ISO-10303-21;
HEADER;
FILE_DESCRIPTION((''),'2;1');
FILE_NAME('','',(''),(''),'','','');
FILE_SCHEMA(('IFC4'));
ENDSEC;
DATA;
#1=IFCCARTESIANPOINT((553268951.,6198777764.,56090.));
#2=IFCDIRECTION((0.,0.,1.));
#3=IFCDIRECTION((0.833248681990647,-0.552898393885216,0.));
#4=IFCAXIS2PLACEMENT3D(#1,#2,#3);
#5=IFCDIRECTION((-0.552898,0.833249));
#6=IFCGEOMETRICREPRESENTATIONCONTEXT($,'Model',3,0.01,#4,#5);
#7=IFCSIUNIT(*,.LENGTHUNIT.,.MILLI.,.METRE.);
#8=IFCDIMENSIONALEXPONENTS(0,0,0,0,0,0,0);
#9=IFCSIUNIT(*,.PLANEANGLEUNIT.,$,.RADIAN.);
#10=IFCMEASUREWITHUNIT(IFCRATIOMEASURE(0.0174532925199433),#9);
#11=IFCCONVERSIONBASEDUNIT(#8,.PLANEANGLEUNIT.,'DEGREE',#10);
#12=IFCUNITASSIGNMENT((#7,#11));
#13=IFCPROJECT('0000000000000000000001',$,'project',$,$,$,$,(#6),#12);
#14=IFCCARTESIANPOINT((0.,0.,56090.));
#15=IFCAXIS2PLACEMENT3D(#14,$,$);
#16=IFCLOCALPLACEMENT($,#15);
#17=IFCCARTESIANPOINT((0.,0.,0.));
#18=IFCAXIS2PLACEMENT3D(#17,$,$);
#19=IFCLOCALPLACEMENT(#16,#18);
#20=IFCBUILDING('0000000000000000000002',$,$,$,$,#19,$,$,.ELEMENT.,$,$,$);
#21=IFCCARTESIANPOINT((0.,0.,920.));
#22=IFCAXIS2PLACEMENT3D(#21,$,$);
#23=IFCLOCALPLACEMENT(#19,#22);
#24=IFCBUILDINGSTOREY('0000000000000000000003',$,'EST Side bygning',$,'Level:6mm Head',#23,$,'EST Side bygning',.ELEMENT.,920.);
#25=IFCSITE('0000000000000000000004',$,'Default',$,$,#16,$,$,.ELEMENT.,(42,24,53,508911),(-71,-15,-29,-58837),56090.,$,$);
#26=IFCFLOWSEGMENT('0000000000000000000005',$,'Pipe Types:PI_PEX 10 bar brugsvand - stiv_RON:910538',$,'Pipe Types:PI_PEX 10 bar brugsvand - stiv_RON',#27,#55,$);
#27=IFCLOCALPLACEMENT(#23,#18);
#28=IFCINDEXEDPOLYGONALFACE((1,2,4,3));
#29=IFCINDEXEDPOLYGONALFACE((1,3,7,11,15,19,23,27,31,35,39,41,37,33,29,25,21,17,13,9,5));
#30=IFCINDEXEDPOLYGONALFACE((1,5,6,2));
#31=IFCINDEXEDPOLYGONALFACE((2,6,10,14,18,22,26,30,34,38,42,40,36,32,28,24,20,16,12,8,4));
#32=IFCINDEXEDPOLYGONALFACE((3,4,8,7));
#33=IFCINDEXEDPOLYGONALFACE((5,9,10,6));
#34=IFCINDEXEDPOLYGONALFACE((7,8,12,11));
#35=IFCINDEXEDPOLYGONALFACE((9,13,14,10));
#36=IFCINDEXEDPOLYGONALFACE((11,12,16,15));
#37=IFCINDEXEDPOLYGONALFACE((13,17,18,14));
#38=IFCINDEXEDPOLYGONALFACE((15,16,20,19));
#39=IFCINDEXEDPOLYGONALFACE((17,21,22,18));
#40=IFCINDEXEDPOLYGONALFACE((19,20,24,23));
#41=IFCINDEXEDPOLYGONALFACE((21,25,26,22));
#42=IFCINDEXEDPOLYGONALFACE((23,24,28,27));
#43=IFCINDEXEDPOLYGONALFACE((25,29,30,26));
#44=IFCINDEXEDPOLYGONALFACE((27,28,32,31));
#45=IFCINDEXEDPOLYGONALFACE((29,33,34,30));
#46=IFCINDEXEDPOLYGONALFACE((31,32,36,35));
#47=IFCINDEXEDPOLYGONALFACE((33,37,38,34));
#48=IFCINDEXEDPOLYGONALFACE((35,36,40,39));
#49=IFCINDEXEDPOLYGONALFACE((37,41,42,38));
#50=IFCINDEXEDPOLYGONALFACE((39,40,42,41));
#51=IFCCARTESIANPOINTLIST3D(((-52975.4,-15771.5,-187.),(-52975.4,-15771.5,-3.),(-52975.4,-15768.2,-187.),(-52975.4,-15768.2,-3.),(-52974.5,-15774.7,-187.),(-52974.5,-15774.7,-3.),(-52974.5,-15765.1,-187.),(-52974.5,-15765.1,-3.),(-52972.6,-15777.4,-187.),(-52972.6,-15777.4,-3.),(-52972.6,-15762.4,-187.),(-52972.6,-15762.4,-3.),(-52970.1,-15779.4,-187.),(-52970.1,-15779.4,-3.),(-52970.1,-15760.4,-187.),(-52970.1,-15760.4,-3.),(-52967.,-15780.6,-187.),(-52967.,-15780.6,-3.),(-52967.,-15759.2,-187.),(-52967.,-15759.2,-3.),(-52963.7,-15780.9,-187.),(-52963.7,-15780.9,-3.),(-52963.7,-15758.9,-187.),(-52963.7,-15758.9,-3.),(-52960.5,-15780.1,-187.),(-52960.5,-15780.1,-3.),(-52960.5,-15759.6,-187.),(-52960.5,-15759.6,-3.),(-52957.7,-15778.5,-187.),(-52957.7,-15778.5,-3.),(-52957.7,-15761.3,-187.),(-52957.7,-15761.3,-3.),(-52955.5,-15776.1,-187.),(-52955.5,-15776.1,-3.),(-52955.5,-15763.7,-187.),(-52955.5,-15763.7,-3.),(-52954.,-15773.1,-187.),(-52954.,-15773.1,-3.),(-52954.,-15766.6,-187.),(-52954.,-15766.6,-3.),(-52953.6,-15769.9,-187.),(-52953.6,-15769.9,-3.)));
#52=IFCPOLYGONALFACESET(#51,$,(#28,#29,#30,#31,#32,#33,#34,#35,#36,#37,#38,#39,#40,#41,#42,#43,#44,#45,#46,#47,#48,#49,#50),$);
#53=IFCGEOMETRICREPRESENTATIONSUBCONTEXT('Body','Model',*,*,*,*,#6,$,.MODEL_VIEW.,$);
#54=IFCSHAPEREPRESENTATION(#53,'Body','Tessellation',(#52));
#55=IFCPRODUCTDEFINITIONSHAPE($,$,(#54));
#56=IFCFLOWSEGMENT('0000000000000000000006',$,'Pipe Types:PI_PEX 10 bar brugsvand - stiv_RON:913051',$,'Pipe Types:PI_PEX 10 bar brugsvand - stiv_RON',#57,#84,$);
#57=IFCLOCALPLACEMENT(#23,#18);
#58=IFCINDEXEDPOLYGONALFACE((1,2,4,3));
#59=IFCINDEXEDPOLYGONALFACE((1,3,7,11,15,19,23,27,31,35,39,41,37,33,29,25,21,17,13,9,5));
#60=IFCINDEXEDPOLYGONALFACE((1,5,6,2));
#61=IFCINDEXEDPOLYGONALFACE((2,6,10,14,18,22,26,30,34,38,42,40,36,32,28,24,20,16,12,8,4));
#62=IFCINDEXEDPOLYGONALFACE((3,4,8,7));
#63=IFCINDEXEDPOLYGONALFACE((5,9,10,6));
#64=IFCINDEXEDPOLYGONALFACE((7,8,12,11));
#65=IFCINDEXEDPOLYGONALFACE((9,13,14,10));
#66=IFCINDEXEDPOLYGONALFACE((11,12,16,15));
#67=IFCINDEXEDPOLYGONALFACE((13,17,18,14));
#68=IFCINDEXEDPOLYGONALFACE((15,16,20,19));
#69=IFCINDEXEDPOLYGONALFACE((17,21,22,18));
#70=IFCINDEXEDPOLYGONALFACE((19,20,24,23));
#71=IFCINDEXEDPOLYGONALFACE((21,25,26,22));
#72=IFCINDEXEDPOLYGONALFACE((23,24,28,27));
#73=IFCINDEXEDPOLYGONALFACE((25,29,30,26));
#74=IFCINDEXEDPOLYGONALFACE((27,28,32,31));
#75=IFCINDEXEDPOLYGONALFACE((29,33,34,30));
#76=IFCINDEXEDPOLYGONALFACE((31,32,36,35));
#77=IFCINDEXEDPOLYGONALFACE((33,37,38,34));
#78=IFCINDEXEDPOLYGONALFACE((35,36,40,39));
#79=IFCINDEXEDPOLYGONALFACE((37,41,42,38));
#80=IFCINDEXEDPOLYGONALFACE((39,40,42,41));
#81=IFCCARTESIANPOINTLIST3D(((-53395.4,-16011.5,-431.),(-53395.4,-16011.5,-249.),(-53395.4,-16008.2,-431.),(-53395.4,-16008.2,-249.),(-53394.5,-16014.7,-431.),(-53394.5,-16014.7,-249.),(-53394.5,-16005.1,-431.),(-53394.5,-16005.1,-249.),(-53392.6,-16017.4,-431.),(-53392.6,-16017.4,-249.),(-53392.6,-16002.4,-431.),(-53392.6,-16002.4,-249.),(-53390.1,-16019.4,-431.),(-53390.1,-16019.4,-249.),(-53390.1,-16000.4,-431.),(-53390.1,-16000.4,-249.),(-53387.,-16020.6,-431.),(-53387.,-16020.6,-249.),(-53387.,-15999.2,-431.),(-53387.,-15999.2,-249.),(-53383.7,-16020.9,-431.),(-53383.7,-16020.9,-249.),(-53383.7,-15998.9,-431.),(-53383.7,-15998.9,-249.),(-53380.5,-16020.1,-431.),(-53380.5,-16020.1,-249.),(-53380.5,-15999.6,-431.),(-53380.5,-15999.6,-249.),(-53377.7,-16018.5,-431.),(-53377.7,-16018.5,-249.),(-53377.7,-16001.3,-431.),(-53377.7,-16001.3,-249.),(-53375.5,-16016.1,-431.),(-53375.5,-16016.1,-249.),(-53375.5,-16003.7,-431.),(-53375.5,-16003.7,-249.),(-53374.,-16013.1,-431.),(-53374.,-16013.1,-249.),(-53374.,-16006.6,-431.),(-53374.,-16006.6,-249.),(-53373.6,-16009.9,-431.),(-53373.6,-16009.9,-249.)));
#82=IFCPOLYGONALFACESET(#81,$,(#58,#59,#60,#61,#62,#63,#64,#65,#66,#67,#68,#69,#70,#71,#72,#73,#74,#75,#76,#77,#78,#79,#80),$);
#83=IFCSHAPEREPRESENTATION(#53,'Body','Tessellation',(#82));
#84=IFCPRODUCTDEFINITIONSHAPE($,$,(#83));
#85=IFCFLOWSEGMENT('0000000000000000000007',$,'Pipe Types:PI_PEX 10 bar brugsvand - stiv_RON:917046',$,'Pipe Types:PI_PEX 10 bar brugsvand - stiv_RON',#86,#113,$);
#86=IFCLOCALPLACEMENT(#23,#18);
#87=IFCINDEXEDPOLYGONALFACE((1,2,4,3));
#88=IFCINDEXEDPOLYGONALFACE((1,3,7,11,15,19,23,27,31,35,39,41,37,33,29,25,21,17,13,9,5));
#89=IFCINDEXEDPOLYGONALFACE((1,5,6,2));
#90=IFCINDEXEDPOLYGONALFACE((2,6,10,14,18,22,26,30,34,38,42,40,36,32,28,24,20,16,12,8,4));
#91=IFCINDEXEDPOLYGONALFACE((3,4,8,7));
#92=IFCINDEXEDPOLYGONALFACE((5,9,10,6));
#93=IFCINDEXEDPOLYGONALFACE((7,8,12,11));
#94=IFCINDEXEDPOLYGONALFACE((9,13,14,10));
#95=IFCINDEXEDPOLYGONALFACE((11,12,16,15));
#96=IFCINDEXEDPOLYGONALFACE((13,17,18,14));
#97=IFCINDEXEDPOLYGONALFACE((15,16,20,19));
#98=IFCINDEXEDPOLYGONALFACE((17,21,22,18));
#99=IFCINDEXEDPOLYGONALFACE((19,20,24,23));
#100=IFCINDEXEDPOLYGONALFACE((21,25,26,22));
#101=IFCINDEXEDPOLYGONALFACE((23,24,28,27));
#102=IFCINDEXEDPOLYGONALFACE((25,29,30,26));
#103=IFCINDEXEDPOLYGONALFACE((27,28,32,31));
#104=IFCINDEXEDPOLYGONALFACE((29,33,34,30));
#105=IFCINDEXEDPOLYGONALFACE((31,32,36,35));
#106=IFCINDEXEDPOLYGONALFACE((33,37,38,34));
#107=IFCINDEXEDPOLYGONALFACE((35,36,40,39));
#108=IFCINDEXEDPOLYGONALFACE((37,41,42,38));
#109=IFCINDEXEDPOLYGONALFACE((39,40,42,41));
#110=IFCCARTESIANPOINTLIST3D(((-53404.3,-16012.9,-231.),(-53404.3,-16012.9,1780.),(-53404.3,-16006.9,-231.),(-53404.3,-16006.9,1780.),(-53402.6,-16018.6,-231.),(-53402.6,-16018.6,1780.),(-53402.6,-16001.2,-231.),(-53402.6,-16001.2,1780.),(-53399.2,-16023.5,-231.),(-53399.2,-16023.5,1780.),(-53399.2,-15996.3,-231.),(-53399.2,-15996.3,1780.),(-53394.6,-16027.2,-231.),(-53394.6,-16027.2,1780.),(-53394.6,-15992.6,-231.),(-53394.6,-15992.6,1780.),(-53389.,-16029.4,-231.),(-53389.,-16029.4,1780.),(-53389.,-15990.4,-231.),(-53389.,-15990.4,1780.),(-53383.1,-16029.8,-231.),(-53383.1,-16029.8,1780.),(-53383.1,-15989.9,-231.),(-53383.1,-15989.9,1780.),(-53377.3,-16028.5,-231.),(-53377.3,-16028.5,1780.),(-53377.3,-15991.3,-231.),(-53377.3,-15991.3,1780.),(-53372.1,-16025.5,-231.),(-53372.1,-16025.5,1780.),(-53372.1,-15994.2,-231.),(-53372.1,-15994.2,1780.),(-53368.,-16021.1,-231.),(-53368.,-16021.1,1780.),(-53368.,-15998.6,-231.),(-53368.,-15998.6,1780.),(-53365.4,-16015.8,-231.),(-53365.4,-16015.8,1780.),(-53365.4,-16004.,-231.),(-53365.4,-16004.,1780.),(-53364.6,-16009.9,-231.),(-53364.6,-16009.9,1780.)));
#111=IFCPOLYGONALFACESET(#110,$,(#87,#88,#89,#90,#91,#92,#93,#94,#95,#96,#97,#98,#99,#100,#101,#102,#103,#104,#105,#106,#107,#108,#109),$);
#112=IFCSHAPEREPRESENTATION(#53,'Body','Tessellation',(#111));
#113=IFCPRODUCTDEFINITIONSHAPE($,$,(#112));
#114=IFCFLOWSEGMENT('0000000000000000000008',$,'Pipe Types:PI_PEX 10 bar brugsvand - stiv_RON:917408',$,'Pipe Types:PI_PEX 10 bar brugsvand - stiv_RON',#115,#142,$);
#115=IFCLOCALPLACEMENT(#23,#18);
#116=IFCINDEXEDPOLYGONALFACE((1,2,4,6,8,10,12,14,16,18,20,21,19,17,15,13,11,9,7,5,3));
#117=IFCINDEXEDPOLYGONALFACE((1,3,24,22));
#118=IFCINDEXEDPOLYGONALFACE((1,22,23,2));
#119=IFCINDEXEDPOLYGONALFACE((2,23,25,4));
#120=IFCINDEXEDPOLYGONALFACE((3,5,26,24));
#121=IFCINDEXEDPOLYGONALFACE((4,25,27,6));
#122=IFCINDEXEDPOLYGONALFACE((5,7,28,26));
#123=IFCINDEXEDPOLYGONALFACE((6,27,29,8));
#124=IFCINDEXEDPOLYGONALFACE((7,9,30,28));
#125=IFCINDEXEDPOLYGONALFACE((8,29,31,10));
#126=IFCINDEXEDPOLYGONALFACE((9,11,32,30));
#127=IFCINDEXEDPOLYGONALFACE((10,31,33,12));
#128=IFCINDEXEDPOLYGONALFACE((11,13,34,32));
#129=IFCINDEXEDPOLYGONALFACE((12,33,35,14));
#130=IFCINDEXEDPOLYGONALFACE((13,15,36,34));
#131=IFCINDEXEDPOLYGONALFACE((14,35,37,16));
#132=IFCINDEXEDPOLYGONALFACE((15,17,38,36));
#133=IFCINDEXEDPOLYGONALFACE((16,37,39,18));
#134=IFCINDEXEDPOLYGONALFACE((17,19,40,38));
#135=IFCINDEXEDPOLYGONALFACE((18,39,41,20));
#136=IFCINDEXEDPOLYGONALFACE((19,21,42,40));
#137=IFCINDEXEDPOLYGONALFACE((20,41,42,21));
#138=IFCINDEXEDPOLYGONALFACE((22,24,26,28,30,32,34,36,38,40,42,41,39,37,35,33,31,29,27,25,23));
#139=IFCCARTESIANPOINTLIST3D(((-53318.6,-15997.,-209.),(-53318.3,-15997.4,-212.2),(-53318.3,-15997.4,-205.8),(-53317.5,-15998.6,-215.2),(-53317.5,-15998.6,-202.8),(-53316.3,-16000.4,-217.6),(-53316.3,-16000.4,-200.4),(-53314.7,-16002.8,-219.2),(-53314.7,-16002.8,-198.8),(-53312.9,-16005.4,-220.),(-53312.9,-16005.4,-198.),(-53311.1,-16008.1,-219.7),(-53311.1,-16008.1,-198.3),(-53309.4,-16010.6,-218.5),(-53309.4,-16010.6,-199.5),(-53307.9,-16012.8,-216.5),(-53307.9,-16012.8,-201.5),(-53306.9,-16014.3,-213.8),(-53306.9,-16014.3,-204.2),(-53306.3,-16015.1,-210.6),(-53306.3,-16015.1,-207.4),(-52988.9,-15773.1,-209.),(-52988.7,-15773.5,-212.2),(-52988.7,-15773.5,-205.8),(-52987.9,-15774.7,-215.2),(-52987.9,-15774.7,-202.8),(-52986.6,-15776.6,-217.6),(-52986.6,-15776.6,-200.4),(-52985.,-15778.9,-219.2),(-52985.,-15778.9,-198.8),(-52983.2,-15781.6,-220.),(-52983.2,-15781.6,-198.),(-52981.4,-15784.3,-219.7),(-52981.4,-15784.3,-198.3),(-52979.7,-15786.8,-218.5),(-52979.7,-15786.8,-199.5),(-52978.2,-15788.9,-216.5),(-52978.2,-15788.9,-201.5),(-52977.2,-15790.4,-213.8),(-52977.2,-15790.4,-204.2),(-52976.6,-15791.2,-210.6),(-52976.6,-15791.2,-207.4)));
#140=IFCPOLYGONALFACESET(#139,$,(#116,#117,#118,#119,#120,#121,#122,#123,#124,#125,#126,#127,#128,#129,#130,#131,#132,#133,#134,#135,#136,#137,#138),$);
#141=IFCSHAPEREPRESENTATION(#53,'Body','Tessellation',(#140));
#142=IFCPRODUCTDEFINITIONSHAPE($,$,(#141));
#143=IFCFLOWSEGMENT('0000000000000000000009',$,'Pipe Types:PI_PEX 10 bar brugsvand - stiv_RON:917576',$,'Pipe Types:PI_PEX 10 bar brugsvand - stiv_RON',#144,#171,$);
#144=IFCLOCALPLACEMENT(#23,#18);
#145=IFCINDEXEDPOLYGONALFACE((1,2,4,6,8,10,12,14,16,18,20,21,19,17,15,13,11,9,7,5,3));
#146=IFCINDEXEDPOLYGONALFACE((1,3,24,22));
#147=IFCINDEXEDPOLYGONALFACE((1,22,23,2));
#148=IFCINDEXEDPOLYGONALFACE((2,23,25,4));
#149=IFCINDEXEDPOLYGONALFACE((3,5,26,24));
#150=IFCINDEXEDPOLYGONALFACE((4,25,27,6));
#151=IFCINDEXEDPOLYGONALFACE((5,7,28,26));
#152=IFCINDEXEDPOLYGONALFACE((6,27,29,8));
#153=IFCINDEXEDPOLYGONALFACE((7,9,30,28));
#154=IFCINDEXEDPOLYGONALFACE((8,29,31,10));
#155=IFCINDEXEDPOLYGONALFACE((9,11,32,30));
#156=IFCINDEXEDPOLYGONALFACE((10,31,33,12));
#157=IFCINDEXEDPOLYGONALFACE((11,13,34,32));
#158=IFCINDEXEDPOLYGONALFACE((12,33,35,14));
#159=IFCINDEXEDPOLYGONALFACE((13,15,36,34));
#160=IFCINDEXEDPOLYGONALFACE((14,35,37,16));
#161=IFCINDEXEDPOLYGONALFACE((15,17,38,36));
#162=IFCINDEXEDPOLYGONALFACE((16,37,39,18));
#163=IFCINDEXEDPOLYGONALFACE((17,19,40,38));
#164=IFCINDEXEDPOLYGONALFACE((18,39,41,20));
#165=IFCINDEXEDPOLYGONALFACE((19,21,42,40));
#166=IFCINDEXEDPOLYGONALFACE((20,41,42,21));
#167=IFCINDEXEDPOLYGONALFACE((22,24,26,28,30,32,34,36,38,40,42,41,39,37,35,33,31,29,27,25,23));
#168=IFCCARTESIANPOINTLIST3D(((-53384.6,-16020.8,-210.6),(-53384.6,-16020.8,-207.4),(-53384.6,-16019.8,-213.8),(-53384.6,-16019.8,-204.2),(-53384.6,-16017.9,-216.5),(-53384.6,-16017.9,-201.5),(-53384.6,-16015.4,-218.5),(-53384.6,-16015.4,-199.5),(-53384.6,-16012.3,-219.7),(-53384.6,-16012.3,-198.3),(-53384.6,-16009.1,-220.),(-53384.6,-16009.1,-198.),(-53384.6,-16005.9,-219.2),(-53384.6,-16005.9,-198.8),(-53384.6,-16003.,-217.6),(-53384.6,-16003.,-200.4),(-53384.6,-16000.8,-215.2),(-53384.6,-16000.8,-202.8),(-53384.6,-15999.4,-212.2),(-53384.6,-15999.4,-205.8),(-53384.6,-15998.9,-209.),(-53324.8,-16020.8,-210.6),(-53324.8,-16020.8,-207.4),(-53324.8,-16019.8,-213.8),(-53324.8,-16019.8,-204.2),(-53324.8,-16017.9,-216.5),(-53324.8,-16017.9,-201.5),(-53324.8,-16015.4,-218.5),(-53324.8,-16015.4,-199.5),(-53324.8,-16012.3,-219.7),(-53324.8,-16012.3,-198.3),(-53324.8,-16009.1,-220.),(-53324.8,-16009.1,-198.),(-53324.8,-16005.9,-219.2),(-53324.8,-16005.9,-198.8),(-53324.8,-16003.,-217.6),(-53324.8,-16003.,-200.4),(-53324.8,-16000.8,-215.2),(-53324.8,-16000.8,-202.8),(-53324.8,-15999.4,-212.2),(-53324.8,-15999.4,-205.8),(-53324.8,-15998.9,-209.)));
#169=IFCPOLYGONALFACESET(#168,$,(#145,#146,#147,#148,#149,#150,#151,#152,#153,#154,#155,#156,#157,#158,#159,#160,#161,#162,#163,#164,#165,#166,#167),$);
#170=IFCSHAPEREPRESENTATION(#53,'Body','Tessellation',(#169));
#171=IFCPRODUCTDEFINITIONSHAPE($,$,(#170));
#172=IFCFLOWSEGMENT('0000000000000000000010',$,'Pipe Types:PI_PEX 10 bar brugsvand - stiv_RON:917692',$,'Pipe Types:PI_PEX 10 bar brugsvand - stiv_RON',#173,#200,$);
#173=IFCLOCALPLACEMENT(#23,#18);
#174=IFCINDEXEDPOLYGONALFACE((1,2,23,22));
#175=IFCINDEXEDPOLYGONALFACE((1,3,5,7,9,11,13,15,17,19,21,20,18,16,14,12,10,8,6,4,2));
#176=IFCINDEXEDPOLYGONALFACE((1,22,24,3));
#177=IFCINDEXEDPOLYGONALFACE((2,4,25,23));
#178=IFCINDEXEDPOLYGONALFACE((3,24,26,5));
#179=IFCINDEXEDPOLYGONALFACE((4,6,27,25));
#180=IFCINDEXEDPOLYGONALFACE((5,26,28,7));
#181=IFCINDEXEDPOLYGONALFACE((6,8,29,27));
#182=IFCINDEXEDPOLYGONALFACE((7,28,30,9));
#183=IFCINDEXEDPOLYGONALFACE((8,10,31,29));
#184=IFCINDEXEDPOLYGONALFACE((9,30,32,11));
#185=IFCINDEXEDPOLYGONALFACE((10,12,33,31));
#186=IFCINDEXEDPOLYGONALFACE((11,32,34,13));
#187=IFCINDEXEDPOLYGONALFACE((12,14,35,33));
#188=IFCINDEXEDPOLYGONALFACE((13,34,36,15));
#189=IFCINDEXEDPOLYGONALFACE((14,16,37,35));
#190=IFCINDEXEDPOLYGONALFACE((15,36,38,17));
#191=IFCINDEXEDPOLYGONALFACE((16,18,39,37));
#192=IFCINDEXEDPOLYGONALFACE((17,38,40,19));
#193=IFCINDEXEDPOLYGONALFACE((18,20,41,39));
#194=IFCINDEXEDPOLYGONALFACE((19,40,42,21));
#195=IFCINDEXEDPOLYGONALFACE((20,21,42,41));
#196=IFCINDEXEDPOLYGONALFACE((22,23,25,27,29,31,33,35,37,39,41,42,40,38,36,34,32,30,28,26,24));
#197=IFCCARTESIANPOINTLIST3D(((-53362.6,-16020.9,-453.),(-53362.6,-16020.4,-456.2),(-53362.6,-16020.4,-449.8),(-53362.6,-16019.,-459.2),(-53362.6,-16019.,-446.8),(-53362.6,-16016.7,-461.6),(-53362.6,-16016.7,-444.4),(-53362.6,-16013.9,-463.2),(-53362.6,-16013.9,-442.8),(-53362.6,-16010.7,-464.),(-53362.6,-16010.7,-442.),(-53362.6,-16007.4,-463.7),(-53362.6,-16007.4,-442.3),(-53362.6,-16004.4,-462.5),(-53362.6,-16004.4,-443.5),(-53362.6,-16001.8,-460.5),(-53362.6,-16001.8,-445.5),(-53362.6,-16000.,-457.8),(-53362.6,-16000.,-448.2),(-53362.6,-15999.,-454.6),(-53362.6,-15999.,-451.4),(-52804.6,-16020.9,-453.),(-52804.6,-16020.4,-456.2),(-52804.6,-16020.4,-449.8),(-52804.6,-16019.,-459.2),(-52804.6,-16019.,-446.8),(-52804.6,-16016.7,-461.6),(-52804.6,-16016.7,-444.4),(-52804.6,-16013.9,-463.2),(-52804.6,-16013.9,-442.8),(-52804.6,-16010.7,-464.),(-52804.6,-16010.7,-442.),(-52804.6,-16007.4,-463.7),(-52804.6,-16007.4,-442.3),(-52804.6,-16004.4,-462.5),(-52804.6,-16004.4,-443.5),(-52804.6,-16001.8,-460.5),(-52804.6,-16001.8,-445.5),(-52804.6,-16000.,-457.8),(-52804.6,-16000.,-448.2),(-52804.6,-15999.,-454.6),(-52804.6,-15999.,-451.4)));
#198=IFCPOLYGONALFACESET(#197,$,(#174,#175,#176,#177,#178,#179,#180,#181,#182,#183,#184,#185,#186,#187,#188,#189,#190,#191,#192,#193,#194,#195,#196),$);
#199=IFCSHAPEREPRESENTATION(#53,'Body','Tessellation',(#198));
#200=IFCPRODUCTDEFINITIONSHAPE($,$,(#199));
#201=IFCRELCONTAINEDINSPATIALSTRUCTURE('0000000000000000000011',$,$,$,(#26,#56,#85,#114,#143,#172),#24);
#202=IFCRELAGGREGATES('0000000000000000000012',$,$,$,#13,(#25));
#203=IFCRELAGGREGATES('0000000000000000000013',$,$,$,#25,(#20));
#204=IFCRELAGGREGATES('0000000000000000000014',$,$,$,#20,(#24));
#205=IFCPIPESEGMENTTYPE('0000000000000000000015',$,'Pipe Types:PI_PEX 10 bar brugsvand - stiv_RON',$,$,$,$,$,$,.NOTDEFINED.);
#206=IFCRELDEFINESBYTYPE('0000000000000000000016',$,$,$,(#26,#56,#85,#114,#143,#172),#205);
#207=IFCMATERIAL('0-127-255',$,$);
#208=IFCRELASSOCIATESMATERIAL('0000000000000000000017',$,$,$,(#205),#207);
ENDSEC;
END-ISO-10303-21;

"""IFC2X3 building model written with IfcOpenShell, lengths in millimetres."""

from ifc_helpers import new_model, entity, si_unit, converted_unit, direction, frame, frame_2d, origin, origin_2d_with_axis, place, context, subcontext, project, spatial, circle, extrude, material, type_object, element, save


model = new_model("IFC2X3")

# Units and contexts
model_context = context("Model", 3, precision=0.01, world=frame((553268951.0, 6198777764.0, 56090.0), z_axis=(0.0, 0.0, 1.0), x_axis=(0.833248681990647, -0.552898393885216, 0.0)), true_north=direction((-0.552898, 0.833249)))
body_context = subcontext(model_context, "Body", "Model", "MODEL_VIEW")
ifc_project = project(units=[si_unit("LENGTHUNIT", "METRE", prefix="MILLI"), converted_unit("PLANEANGLEUNIT", "DEGREE", entity("IfcRatioMeasure", 0.0174532925199433), si_unit("PLANEANGLEUNIT", "RADIAN"), dimensions=[0, 0, 0, 0, 0, 0, 0])], contexts=[model_context])

# Site, building, storey
site_placement = place(None, frame((0.0, 0.0, 56090.0)))
site = spatial("IfcSite", under=ifc_project, at=site_placement, Name="Default", CompositionType="ELEMENT", RefLatitude=(42, 24, 53, 508911), RefLongitude=(-71, -15, -29, -58837), RefElevation=56090.0)
building_placement = place(site_placement, origin())
building = spatial("IfcBuilding", under=site, at=building_placement, CompositionType="ELEMENT")
storey_placement = place(building_placement, frame((0.0, 0.0, 920.0)))
storey = spatial("IfcBuildingStorey", under=building, at=storey_placement, Name="EST Side bygning", ObjectType="Level:6mm Head", LongName="EST Side bygning", CompositionType="ELEMENT", Elevation=920.0)

# Flow segments
ifc_material_1 = material(Name="0-127-255")
pipe_segment_type_1 = type_object("IfcPipeSegmentType", Name="Pipe Types:PI_PEX 10 bar brugsvand - stiv_RON", PredefinedType="NOTDEFINED", material=ifc_material_1)
flow_segment_1_placement = place(storey_placement, origin())
element("IfcFlowSegment", 1, at=flow_segment_1_placement, inside=storey, type_object=pipe_segment_type_1, Name="Pipe Types:PI_PEX 10 bar brugsvand - stiv_RON:910538", ObjectType="Pipe Types:PI_PEX 10 bar brugsvand - stiv_RON", context=body_context, shape_type="SweptSolid", body=[
    extrude(circle(Radius=11.0, at=origin_2d_with_axis()), frame((-52964.6, -15769.9, -187.0)), (0.0, 0.0, 1.0), 184.0),
])
flow_segment_2_placement = place(storey_placement, origin())
element("IfcFlowSegment", 2, at=flow_segment_2_placement, inside=storey, type_object=pipe_segment_type_1, Name="Pipe Types:PI_PEX 10 bar brugsvand - stiv_RON:913051", ObjectType="Pipe Types:PI_PEX 10 bar brugsvand - stiv_RON", context=body_context, shape_type="SweptSolid", body=[
    extrude(circle(Radius=11.0, at=origin_2d_with_axis()), frame((-53384.6, -16009.9, -431.0)), (0.0, 0.0, 1.0), 182.0),
])
flow_segment_3_placement = place(storey_placement, origin())
element("IfcFlowSegment", 3, at=flow_segment_3_placement, inside=storey, type_object=pipe_segment_type_1, Name="Pipe Types:PI_PEX 10 bar brugsvand - stiv_RON:917046", ObjectType="Pipe Types:PI_PEX 10 bar brugsvand - stiv_RON", context=body_context, shape_type="SweptSolid", body=[
    extrude(circle(Radius=20.0, at=origin_2d_with_axis()), frame((-53384.6, -16009.9, -231.0)), (0.0, 0.0, 1.0), 2011.0),
])
flow_segment_4_placement = place(storey_placement, origin())
element("IfcFlowSegment", 4, at=flow_segment_4_placement, inside=storey, type_object=pipe_segment_type_1, Name="Pipe Types:PI_PEX 10 bar brugsvand - stiv_RON:917408", ObjectType="Pipe Types:PI_PEX 10 bar brugsvand - stiv_RON", context=body_context, shape_type="SweptSolid", body=[
    extrude(circle(Radius=11.0, at=origin_2d_with_axis()), frame((-53312.4, -16006.1, -209.0), z_axis=(0.827326, 0.561722, 0.0), x_axis=(-0.561722, 0.827326, 0.0)), (0.0, 0.0, 1.0), 398.5),
])
flow_segment_5_placement = place(storey_placement, origin())
element("IfcFlowSegment", 5, at=flow_segment_5_placement, inside=storey, type_object=pipe_segment_type_1, Name="Pipe Types:PI_PEX 10 bar brugsvand - stiv_RON:917576", ObjectType="Pipe Types:PI_PEX 10 bar brugsvand - stiv_RON", context=body_context, shape_type="SweptSolid", body=[
    extrude(circle(Radius=11.0, at=origin_2d_with_axis()), frame((-53384.6, -16009.9, -209.0), z_axis=(1.0, 0.0, 0.0), x_axis=(0.0, 1.0, 0.0)), (0.0, 0.0, 1.0), 59.8),
])
flow_segment_6_placement = place(storey_placement, origin())
element("IfcFlowSegment", 6, at=flow_segment_6_placement, inside=storey, type_object=pipe_segment_type_1, Name="Pipe Types:PI_PEX 10 bar brugsvand - stiv_RON:917692", ObjectType="Pipe Types:PI_PEX 10 bar brugsvand - stiv_RON", context=body_context, shape_type="SweptSolid", body=[
    extrude(circle(Radius=11.0, at=frame_2d((0.0, 0.0), x_axis=(1.0, 0.0))), frame((-53362.6, -16009.9, -453.0), z_axis=(1.0, 0.0, 0.0), x_axis=(0.0, -1.0, 0.0)), (0.0, 0.0, 1.0), 558.0),
])

save(model, "model.ifc")
